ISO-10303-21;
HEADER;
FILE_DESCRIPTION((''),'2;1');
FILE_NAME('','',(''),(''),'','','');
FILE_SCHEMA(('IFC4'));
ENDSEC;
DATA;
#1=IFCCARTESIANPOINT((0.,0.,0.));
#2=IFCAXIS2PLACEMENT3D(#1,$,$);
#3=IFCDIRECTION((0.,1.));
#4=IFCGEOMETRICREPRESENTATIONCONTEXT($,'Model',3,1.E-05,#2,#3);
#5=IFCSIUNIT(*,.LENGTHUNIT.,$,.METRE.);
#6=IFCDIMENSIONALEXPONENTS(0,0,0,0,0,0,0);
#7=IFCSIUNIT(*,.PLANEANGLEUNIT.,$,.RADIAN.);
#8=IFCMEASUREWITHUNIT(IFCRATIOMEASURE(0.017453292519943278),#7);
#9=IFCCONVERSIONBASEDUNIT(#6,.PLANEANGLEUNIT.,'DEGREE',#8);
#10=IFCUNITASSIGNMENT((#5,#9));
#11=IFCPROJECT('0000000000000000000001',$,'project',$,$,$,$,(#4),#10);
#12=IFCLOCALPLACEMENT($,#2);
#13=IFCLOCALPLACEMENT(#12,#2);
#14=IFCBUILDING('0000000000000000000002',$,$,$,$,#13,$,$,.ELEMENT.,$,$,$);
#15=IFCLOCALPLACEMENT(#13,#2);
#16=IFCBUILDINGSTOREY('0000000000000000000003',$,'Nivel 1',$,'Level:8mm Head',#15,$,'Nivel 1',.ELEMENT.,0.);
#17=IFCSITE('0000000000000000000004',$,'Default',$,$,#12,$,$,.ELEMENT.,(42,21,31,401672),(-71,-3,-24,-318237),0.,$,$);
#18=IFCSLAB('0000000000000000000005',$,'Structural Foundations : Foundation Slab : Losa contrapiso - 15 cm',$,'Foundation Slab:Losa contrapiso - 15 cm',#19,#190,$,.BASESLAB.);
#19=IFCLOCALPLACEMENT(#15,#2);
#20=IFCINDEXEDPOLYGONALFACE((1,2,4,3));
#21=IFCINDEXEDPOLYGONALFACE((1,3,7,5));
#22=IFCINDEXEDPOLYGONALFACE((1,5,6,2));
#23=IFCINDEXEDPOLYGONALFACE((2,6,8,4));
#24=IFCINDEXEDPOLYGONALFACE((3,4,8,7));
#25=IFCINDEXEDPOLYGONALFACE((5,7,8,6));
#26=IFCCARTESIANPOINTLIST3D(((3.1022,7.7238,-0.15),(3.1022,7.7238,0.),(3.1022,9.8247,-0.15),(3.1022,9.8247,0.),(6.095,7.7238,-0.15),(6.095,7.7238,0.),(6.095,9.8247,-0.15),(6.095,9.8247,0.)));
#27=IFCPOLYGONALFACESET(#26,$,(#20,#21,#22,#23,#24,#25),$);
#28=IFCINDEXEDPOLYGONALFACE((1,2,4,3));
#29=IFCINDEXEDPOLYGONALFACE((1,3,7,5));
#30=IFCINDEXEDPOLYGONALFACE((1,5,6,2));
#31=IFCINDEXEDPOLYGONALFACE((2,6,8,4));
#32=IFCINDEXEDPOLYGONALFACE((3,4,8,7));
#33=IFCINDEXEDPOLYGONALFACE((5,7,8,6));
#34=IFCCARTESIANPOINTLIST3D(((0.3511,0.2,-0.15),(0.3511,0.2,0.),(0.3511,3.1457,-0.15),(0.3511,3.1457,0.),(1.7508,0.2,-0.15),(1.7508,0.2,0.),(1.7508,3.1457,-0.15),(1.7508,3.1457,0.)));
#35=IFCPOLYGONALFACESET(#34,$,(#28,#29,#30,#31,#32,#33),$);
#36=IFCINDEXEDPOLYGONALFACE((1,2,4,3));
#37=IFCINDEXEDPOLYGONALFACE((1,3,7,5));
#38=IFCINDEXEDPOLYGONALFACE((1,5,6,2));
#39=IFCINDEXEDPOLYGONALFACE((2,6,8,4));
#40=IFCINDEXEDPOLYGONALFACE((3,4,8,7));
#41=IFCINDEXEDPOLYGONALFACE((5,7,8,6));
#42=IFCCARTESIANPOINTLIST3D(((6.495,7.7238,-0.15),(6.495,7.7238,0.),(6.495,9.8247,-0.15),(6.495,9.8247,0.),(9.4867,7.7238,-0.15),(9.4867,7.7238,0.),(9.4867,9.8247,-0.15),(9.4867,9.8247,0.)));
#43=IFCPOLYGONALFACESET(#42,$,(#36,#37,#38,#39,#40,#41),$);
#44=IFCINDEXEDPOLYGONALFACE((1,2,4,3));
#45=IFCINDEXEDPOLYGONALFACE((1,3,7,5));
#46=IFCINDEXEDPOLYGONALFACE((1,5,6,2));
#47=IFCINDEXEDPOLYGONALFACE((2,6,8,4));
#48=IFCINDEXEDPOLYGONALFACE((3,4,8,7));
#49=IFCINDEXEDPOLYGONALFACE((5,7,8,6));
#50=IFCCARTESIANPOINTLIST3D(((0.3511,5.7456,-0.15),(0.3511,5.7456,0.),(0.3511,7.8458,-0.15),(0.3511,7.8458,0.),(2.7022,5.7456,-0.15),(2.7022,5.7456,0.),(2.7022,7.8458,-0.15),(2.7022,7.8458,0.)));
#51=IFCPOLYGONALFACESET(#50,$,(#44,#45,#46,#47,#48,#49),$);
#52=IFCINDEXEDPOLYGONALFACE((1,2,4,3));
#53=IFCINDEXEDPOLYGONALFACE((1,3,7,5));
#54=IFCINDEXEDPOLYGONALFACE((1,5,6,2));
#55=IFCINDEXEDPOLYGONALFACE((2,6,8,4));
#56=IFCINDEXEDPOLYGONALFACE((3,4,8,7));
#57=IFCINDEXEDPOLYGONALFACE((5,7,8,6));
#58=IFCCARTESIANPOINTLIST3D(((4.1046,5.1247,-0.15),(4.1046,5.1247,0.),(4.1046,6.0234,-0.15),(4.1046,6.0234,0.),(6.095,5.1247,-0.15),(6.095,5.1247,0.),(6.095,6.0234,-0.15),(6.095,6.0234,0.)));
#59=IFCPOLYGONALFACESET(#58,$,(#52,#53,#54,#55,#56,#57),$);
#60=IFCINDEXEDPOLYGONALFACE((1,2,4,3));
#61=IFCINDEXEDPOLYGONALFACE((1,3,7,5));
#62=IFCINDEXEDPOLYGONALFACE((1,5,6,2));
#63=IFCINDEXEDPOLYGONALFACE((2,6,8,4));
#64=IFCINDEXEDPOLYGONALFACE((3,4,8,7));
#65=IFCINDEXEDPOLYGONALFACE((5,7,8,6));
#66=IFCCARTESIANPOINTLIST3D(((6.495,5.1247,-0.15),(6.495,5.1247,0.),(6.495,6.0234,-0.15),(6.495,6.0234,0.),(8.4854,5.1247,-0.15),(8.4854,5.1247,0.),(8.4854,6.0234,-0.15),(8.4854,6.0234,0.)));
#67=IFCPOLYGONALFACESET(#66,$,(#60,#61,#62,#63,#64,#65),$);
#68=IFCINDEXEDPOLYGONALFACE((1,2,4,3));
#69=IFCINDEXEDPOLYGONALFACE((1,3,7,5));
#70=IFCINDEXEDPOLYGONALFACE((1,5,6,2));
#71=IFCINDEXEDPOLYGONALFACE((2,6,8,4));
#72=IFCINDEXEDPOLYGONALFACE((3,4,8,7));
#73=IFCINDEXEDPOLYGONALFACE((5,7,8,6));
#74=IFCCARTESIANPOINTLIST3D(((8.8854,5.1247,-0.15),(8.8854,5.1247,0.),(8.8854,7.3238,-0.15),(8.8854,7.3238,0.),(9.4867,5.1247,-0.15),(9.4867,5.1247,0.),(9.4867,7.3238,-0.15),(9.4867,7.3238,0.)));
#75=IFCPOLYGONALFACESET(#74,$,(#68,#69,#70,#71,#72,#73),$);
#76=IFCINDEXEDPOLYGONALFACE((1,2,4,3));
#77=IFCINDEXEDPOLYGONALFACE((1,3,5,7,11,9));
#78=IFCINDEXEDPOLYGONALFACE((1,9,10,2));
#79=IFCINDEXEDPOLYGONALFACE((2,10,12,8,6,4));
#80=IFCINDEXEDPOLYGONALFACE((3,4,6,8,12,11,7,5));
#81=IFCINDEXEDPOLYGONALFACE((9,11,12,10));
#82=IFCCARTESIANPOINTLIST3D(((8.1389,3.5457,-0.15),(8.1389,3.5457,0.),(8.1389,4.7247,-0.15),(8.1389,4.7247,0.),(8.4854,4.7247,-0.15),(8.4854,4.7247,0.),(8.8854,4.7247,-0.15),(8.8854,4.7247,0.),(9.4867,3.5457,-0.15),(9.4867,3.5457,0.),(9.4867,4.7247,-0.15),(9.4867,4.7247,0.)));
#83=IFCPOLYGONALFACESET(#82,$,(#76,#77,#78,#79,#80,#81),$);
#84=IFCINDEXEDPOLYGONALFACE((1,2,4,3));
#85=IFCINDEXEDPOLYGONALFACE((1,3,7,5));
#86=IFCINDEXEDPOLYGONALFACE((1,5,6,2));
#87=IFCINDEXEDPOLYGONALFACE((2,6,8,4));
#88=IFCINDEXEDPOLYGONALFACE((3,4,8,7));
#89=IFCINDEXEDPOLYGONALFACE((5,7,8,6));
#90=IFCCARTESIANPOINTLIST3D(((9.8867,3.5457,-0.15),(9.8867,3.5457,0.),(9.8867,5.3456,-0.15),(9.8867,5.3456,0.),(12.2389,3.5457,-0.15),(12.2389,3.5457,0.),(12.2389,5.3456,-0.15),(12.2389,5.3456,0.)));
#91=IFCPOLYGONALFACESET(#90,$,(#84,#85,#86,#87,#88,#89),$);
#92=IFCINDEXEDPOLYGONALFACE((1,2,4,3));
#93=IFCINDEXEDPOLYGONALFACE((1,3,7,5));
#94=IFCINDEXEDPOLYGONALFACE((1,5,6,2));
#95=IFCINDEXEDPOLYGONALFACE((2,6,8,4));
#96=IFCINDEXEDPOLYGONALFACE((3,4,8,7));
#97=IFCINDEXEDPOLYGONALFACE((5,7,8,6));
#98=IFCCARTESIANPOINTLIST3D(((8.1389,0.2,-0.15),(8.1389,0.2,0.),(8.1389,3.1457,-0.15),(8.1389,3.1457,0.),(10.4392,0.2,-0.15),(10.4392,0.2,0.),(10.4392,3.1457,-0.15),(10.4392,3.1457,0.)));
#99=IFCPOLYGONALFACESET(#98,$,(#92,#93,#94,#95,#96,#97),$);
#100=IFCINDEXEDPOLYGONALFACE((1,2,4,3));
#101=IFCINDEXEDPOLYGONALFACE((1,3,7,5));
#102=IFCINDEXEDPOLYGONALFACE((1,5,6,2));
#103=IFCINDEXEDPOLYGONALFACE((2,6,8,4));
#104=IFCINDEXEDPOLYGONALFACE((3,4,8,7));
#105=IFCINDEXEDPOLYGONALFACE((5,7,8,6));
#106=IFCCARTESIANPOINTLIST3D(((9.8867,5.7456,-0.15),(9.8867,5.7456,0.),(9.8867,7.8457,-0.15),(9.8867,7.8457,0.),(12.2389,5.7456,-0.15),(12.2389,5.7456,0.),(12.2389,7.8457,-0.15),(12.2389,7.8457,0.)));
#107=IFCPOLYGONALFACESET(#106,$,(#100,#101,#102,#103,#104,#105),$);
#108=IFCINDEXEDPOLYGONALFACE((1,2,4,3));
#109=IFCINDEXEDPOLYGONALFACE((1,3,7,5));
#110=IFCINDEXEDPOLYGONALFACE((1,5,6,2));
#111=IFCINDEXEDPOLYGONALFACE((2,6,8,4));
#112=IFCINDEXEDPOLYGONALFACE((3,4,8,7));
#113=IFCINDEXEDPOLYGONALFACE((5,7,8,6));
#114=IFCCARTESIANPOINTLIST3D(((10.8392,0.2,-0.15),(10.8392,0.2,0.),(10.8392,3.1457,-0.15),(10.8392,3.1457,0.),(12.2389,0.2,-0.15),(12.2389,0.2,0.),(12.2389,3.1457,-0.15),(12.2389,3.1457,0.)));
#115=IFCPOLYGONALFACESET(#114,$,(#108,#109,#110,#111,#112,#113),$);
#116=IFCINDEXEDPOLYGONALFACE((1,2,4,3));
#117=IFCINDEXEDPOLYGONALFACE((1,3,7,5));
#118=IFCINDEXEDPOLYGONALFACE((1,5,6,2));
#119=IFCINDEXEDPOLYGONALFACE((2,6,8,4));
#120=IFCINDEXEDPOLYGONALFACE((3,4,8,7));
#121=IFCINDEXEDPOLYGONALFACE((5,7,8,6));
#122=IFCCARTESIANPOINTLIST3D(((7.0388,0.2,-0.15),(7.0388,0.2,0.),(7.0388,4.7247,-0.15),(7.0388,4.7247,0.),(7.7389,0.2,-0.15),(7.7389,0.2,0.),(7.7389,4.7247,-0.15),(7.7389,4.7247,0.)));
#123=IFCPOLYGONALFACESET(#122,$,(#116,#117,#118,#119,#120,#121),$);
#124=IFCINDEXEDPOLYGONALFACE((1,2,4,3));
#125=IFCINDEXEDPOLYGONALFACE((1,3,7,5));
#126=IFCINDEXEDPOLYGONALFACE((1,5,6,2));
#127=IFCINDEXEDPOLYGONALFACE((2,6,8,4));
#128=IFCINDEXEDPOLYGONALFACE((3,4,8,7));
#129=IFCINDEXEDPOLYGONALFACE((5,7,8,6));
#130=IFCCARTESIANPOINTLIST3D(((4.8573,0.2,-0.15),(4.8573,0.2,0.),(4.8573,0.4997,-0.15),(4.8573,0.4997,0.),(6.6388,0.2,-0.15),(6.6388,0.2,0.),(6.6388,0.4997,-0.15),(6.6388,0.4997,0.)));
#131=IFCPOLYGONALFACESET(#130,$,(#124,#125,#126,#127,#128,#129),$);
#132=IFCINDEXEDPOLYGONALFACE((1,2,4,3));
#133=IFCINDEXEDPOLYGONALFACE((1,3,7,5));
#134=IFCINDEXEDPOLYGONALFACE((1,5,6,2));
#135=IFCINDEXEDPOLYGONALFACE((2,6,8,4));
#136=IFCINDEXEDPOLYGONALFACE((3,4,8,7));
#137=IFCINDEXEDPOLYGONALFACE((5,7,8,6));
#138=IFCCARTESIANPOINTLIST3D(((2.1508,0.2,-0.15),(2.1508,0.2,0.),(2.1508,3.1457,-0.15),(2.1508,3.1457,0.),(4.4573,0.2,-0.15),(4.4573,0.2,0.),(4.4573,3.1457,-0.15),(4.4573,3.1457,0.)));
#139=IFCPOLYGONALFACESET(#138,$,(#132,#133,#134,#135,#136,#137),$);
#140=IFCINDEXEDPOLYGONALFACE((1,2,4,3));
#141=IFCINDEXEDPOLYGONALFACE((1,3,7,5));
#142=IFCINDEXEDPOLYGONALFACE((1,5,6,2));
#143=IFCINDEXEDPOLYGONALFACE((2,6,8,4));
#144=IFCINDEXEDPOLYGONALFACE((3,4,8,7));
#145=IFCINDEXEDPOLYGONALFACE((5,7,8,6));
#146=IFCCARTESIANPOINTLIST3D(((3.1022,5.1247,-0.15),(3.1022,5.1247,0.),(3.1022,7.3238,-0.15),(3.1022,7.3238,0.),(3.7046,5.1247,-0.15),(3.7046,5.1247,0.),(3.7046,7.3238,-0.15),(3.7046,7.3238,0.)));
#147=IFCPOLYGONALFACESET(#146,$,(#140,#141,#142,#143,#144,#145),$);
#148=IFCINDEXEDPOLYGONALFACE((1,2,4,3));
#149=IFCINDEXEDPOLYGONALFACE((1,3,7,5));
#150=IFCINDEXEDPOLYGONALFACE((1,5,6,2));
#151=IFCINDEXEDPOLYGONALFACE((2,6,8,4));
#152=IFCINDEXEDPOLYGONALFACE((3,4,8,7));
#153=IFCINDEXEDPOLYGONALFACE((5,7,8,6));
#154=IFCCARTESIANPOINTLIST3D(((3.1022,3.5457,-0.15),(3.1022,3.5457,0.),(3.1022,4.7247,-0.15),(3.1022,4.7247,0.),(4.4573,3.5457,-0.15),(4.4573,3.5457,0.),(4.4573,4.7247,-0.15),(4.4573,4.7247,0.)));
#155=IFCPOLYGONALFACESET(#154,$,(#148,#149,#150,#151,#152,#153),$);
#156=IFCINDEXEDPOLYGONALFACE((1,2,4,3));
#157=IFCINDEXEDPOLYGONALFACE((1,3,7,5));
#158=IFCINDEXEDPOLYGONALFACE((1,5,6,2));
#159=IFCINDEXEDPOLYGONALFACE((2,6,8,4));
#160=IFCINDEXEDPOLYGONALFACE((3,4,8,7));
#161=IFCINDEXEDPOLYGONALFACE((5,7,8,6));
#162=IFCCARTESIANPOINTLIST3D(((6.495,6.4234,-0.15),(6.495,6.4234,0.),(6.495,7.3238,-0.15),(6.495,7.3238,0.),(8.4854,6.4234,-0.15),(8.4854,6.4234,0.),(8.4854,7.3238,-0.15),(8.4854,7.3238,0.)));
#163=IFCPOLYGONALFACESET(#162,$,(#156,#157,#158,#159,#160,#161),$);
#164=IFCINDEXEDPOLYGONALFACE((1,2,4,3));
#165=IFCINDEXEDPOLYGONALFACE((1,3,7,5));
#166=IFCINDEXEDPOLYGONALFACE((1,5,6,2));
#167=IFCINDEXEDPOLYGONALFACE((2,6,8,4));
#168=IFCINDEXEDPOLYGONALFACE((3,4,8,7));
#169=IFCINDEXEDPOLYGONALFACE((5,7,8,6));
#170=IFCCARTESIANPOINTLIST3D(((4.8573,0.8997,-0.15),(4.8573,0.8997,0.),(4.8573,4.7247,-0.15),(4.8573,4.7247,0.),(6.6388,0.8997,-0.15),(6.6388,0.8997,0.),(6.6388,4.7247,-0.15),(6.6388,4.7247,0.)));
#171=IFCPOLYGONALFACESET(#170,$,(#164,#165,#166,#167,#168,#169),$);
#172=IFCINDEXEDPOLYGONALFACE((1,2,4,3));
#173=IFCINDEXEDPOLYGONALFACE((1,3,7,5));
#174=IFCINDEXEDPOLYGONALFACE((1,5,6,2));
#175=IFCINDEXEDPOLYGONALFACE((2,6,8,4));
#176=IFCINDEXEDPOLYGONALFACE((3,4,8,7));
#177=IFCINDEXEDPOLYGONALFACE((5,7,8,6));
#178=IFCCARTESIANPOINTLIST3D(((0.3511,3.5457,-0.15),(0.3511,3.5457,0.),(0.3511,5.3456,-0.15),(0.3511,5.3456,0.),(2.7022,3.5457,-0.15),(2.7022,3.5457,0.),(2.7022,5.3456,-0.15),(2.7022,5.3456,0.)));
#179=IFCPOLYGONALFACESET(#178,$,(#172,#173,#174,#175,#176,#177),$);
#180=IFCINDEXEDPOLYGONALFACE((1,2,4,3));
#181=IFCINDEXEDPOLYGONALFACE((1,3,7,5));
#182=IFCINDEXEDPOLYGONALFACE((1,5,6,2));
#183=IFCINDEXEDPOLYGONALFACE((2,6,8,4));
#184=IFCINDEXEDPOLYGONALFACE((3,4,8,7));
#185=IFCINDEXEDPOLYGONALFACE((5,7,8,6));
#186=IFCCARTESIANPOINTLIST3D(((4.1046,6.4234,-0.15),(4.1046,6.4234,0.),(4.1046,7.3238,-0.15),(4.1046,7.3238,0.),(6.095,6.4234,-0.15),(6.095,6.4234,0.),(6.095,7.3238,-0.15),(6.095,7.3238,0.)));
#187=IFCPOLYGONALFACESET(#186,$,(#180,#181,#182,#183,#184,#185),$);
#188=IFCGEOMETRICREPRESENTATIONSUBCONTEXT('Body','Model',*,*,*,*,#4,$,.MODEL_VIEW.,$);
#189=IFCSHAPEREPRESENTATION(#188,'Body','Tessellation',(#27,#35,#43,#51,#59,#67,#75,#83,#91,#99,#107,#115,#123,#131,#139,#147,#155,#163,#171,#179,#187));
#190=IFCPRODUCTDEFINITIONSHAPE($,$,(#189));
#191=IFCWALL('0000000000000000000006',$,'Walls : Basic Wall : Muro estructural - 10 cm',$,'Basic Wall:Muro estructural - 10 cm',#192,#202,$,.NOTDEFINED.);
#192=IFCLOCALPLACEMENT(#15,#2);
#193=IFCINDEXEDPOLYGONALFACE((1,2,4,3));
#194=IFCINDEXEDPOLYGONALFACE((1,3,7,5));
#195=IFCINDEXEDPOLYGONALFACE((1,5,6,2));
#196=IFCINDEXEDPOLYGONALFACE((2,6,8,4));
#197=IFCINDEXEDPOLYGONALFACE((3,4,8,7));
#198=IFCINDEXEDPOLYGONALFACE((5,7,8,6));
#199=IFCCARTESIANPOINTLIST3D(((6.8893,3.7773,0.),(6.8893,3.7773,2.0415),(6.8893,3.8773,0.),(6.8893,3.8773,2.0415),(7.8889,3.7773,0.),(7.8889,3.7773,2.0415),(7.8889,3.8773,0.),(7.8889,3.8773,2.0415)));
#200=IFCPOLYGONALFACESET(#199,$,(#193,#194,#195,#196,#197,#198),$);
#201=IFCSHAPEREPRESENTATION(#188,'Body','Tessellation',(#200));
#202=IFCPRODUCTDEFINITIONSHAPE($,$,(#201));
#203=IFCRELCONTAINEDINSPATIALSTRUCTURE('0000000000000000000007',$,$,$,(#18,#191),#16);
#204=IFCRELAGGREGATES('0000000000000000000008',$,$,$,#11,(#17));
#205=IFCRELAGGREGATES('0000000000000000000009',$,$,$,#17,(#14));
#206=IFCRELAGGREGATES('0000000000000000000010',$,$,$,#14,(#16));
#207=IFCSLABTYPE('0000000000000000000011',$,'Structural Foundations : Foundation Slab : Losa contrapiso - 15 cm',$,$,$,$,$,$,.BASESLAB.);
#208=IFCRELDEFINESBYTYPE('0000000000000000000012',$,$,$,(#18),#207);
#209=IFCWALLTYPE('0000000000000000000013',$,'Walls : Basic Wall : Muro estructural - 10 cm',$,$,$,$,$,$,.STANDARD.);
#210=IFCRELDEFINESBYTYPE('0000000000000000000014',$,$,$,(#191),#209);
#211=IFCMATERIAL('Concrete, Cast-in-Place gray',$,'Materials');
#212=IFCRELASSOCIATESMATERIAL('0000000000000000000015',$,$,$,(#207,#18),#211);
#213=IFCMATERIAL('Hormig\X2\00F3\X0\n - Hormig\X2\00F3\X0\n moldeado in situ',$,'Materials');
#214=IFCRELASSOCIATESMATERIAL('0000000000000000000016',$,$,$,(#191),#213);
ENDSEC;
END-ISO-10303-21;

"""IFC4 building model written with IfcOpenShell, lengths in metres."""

from ifc_helpers import new_model, entity, si_unit, converted_unit, direction, frame, origin, place, context, subcontext, project, spatial, indexed_curve, outline, extrude, material, type_object, element, save


model = new_model("IFC4")

# Units and contexts
model_context = context("Model", 3, precision=1e-05, world=origin(), true_north=direction((0.0, 1.0)))
body_context = subcontext(model_context, "Body", "Model", "MODEL_VIEW")
ifc_project = project(units=[si_unit("LENGTHUNIT", "METRE"), converted_unit("PLANEANGLEUNIT", "DEGREE", entity("IfcRatioMeasure", 0.017453292519943278), si_unit("PLANEANGLEUNIT", "RADIAN"), dimensions=[0, 0, 0, 0, 0, 0, 0])], contexts=[model_context])

# Site, building, storey
site_placement = place(None, origin())
site = spatial("IfcSite", under=ifc_project, at=site_placement, Name="Default", CompositionType="ELEMENT", RefLatitude=(42, 21, 31, 401672), RefLongitude=(-71, -3, -24, -318237), RefElevation=0.0)
building_placement = place(site_placement, origin())
building = spatial("IfcBuilding", under=site, at=building_placement, CompositionType="ELEMENT")
storey_placement = place(building_placement, origin())
storey = spatial("IfcBuildingStorey", under=building, at=storey_placement, Name="Nivel 1", ObjectType="Level:8mm Head", LongName="Nivel 1", CompositionType="ELEMENT", Elevation=0.0)

# Slab
ifc_material_1 = material(Name="Concrete, Cast-in-Place gray", Category="Materials")
slab_type = type_object("IfcSlabType", Name="Structural Foundations : Foundation Slab : Losa contrapiso - 15 cm", PredefinedType="BASESLAB", material=ifc_material_1)
slab_placement = place(storey_placement, origin())
element("IfcSlab", 1, at=slab_placement, inside=storey, type_object=slab_type, material=ifc_material_1, Name="Structural Foundations : Foundation Slab : Losa contrapiso - 15 cm", ObjectType="Foundation Slab:Losa contrapiso - 15 cm", PredefinedType="BASESLAB", context=body_context, shape_type="SweptSolid", body=[
    extrude(outline(indexed_curve([(-1.0505, -1.4964), (1.0505, -1.4964), (1.0505, 1.4964), (-1.0505, 1.4964), (-1.0505, -1.4964)], self_intersect=False)), frame((4.5986, 8.7743, -0.15), z_axis=(0.0, 0.0, 1.0), x_axis=(0.0, -1.0, 0.0)), (0.0, 0.0, 1.0), 0.15),
    extrude(outline(indexed_curve([(-0.6998, -1.4729), (0.6998, -1.4729), (0.6998, 1.4729), (-0.6998, 1.4729), (-0.6998, -1.4729)], self_intersect=False)), frame((1.051, 1.6729, -0.15), z_axis=(0.0, 0.0, 1.0), x_axis=(-1.0, 0.0, 0.0)), (0.0, 0.0, 1.0), 0.15),
    extrude(outline(indexed_curve([(-1.4958, -1.0505), (1.4958, -1.0505), (1.4958, 1.0505), (-1.4958, 1.0505), (-1.4958, -1.0505)], self_intersect=False)), frame((7.9908, 8.7743, -0.15)), (0.0, 0.0, 1.0), 0.15),
    extrude(outline(indexed_curve([(-1.1755, -1.0501), (1.1755, -1.0501), (1.1755, 1.0501), (-1.1755, 1.0501), (-1.1755, -1.0501)], self_intersect=False)), frame((1.5266, 6.7957, -0.15), z_axis=(0.0, 0.0, 1.0), x_axis=(-1.0, 0.0, 0.0)), (0.0, 0.0, 1.0), 0.15),
    extrude(outline(indexed_curve([(-0.4493, -0.9952), (0.4493, -0.9952), (0.4493, 0.9952), (-0.4493, 0.9952), (-0.4493, -0.9952)], self_intersect=False)), frame((5.0998, 5.574, -0.15), z_axis=(0.0, 0.0, 1.0), x_axis=(0.0, 1.0, 0.0)), (0.0, 0.0, 1.0), 0.15),
    extrude(outline(indexed_curve([(-0.9952, -0.4493), (0.9952, -0.4493), (0.9952, 0.4493), (-0.9952, 0.4493), (-0.9952, -0.4493)], self_intersect=False)), frame((7.4902, 5.574, -0.15)), (0.0, 0.0, 1.0), 0.15),
    extrude(outline(indexed_curve([(-0.3007, -1.0996), (0.3007, -1.0996), (0.3007, 1.0996), (-0.3007, 1.0996), (-0.3007, -1.0996)], self_intersect=False)), frame((9.186, 6.2242, -0.15), z_axis=(0.0, 0.0, 1.0), x_axis=(-1.0, 0.0, 0.0)), (0.0, 0.0, 1.0), 0.15),
    extrude(outline(indexed_curve([(-0.786, -0.7164), (0.393, -0.7164), (0.393, -0.1151), (0.393, 0.2849), (0.393, 0.6314), (-0.786, 0.6314), (-0.786, -0.7164)], self_intersect=False)), frame((8.7703, 4.3317, -0.15), z_axis=(0.0, 0.0, 1.0), x_axis=(0.0, 1.0, 0.0)), (0.0, 0.0, 1.0), 0.15),
    extrude(outline(indexed_curve([(-0.8999, -1.1761), (0.8999, -1.1761), (0.8999, 1.1761), (-0.8999, 1.1761), (-0.8999, -1.1761)], self_intersect=False)), frame((11.0628, 4.4456, -0.15), z_axis=(0.0, 0.0, 1.0), x_axis=(0.0, -1.0, 0.0)), (0.0, 0.0, 1.0), 0.15),
    extrude(outline(indexed_curve([(-1.4729, -1.1502), (1.4729, -1.1502), (1.4729, 1.1502), (-1.4729, 1.1502), (-1.4729, -1.1502)], self_intersect=False)), frame((9.289, 1.6729, -0.15), z_axis=(0.0, 0.0, 1.0), x_axis=(0.0, -1.0, 0.0)), (0.0, 0.0, 1.0), 0.15),
    extrude(outline(indexed_curve([(-1.05, -1.1761), (1.05, -1.1761), (1.05, 1.1761), (-1.05, 1.1761), (-1.05, -1.1761)], self_intersect=False)), frame((11.0628, 6.7956, -0.15), z_axis=(0.0, 0.0, 1.0), x_axis=(0.0, -1.0, 0.0)), (0.0, 0.0, 1.0), 0.15),
    extrude(outline(indexed_curve([(-1.4729, -0.6998), (1.4729, -0.6998), (1.4729, 0.6998), (-1.4729, 0.6998), (-1.4729, -0.6998)], self_intersect=False)), frame((11.539, 1.6729, -0.15), z_axis=(0.0, 0.0, 1.0), x_axis=(0.0, -1.0, 0.0)), (0.0, 0.0, 1.0), 0.15),
    extrude(outline(indexed_curve([(-2.2623, -0.35), (2.2623, -0.35), (2.2623, 0.35), (-2.2623, 0.35), (-2.2623, -0.35)], self_intersect=False)), frame((7.3889, 2.4623, -0.15), z_axis=(0.0, 0.0, 1.0), x_axis=(0.0, -1.0, 0.0)), (0.0, 0.0, 1.0), 0.15),
    extrude(outline(indexed_curve([(-0.1498, -0.8908), (0.1498, -0.8908), (0.1498, 0.8908), (-0.1498, 0.8908), (-0.1498, -0.8908)], self_intersect=False)), frame((5.748, 0.3498, -0.15), z_axis=(0.0, 0.0, 1.0), x_axis=(0.0, -1.0, 0.0)), (0.0, 0.0, 1.0), 0.15),
    extrude(outline(indexed_curve([(-1.4729, -1.1532), (1.4729, -1.1532), (1.4729, 1.1532), (-1.4729, 1.1532), (-1.4729, -1.1532)], self_intersect=False)), frame((3.304, 1.6729, -0.15), z_axis=(0.0, 0.0, 1.0), x_axis=(0.0, -1.0, 0.0)), (0.0, 0.0, 1.0), 0.15),
    extrude(outline(indexed_curve([(-1.0996, -0.3012), (1.0996, -0.3012), (1.0996, 0.3012), (-1.0996, 0.3012), (-1.0996, -0.3012)], self_intersect=False)), frame((3.4034, 6.2242, -0.15), z_axis=(0.0, 0.0, 1.0), x_axis=(0.0, -1.0, 0.0)), (0.0, 0.0, 1.0), 0.15),
    extrude(outline(indexed_curve([(-0.5895, -0.6776), (0.5895, -0.6776), (0.5895, 0.6776), (-0.5895, 0.6776), (-0.5895, -0.6776)], self_intersect=False)), frame((3.7797, 4.1352, -0.15), z_axis=(0.0, 0.0, 1.0), x_axis=(0.0, 1.0, 0.0)), (0.0, 0.0, 1.0), 0.15),
    extrude(outline(indexed_curve([(-0.9952, -0.4502), (0.9952, -0.4502), (0.9952, 0.4502), (-0.9952, 0.4502), (-0.9952, -0.4502)], self_intersect=False)), frame((7.4902, 6.8736, -0.15)), (0.0, 0.0, 1.0), 0.15),
    extrude(outline(indexed_curve([(-1.9125, -0.8908), (1.9125, -0.8908), (1.9125, 0.8908), (-1.9125, 0.8908), (-1.9125, -0.8908)], self_intersect=False)), frame((5.748, 2.8122, -0.15), z_axis=(0.0, 0.0, 1.0), x_axis=(0.0, -1.0, 0.0)), (0.0, 0.0, 1.0), 0.15),
    extrude(outline(indexed_curve([(-1.1755, -0.8999), (1.1755, -0.8999), (1.1755, 0.8999), (-1.1755, 0.8999), (-1.1755, -0.8999)], self_intersect=False)), frame((1.5266, 4.4456, -0.15), z_axis=(0.0, 0.0, 1.0), x_axis=(-1.0, 0.0, 0.0)), (0.0, 0.0, 1.0), 0.15),
    extrude(outline(indexed_curve([(-0.4502, -0.9952), (0.4502, -0.9952), (0.4502, 0.9952), (-0.4502, 0.9952), (-0.4502, -0.9952)], self_intersect=False)), frame((5.0998, 6.8736, -0.15), z_axis=(0.0, 0.0, 1.0), x_axis=(0.0, -1.0, 0.0)), (0.0, 0.0, 1.0), 0.15),
])

# Wall
ifc_material_2 = material(Name="Hormigón - Hormigón moldeado in situ", Category="Materials")
wall_type_1 = type_object("IfcWallType", Name="Walls : Basic Wall : Muro estructural - 10 cm", PredefinedType="STANDARD")
wall_1_placement = place(storey_placement, frame((6.8893, 3.8273, 0.0)))
element("IfcWall", 2, at=wall_1_placement, inside=storey, type_object=wall_type_1, material=ifc_material_2, Name="Walls : Basic Wall : Muro estructural - 10 cm", ObjectType="Basic Wall:Muro estructural - 10 cm", PredefinedType="NOTDEFINED", context=body_context, shape_type="SweptSolid", body=[
    extrude(outline(indexed_curve([(0.9996, 0.05), (0.0, 0.05), (0.0, -0.05), (0.9996, -0.05), (0.9996, 0.05)], self_intersect=False)), origin(), (0.0, 0.0, 1.0), 2.0415),
])

save(model, "model.ifc")
